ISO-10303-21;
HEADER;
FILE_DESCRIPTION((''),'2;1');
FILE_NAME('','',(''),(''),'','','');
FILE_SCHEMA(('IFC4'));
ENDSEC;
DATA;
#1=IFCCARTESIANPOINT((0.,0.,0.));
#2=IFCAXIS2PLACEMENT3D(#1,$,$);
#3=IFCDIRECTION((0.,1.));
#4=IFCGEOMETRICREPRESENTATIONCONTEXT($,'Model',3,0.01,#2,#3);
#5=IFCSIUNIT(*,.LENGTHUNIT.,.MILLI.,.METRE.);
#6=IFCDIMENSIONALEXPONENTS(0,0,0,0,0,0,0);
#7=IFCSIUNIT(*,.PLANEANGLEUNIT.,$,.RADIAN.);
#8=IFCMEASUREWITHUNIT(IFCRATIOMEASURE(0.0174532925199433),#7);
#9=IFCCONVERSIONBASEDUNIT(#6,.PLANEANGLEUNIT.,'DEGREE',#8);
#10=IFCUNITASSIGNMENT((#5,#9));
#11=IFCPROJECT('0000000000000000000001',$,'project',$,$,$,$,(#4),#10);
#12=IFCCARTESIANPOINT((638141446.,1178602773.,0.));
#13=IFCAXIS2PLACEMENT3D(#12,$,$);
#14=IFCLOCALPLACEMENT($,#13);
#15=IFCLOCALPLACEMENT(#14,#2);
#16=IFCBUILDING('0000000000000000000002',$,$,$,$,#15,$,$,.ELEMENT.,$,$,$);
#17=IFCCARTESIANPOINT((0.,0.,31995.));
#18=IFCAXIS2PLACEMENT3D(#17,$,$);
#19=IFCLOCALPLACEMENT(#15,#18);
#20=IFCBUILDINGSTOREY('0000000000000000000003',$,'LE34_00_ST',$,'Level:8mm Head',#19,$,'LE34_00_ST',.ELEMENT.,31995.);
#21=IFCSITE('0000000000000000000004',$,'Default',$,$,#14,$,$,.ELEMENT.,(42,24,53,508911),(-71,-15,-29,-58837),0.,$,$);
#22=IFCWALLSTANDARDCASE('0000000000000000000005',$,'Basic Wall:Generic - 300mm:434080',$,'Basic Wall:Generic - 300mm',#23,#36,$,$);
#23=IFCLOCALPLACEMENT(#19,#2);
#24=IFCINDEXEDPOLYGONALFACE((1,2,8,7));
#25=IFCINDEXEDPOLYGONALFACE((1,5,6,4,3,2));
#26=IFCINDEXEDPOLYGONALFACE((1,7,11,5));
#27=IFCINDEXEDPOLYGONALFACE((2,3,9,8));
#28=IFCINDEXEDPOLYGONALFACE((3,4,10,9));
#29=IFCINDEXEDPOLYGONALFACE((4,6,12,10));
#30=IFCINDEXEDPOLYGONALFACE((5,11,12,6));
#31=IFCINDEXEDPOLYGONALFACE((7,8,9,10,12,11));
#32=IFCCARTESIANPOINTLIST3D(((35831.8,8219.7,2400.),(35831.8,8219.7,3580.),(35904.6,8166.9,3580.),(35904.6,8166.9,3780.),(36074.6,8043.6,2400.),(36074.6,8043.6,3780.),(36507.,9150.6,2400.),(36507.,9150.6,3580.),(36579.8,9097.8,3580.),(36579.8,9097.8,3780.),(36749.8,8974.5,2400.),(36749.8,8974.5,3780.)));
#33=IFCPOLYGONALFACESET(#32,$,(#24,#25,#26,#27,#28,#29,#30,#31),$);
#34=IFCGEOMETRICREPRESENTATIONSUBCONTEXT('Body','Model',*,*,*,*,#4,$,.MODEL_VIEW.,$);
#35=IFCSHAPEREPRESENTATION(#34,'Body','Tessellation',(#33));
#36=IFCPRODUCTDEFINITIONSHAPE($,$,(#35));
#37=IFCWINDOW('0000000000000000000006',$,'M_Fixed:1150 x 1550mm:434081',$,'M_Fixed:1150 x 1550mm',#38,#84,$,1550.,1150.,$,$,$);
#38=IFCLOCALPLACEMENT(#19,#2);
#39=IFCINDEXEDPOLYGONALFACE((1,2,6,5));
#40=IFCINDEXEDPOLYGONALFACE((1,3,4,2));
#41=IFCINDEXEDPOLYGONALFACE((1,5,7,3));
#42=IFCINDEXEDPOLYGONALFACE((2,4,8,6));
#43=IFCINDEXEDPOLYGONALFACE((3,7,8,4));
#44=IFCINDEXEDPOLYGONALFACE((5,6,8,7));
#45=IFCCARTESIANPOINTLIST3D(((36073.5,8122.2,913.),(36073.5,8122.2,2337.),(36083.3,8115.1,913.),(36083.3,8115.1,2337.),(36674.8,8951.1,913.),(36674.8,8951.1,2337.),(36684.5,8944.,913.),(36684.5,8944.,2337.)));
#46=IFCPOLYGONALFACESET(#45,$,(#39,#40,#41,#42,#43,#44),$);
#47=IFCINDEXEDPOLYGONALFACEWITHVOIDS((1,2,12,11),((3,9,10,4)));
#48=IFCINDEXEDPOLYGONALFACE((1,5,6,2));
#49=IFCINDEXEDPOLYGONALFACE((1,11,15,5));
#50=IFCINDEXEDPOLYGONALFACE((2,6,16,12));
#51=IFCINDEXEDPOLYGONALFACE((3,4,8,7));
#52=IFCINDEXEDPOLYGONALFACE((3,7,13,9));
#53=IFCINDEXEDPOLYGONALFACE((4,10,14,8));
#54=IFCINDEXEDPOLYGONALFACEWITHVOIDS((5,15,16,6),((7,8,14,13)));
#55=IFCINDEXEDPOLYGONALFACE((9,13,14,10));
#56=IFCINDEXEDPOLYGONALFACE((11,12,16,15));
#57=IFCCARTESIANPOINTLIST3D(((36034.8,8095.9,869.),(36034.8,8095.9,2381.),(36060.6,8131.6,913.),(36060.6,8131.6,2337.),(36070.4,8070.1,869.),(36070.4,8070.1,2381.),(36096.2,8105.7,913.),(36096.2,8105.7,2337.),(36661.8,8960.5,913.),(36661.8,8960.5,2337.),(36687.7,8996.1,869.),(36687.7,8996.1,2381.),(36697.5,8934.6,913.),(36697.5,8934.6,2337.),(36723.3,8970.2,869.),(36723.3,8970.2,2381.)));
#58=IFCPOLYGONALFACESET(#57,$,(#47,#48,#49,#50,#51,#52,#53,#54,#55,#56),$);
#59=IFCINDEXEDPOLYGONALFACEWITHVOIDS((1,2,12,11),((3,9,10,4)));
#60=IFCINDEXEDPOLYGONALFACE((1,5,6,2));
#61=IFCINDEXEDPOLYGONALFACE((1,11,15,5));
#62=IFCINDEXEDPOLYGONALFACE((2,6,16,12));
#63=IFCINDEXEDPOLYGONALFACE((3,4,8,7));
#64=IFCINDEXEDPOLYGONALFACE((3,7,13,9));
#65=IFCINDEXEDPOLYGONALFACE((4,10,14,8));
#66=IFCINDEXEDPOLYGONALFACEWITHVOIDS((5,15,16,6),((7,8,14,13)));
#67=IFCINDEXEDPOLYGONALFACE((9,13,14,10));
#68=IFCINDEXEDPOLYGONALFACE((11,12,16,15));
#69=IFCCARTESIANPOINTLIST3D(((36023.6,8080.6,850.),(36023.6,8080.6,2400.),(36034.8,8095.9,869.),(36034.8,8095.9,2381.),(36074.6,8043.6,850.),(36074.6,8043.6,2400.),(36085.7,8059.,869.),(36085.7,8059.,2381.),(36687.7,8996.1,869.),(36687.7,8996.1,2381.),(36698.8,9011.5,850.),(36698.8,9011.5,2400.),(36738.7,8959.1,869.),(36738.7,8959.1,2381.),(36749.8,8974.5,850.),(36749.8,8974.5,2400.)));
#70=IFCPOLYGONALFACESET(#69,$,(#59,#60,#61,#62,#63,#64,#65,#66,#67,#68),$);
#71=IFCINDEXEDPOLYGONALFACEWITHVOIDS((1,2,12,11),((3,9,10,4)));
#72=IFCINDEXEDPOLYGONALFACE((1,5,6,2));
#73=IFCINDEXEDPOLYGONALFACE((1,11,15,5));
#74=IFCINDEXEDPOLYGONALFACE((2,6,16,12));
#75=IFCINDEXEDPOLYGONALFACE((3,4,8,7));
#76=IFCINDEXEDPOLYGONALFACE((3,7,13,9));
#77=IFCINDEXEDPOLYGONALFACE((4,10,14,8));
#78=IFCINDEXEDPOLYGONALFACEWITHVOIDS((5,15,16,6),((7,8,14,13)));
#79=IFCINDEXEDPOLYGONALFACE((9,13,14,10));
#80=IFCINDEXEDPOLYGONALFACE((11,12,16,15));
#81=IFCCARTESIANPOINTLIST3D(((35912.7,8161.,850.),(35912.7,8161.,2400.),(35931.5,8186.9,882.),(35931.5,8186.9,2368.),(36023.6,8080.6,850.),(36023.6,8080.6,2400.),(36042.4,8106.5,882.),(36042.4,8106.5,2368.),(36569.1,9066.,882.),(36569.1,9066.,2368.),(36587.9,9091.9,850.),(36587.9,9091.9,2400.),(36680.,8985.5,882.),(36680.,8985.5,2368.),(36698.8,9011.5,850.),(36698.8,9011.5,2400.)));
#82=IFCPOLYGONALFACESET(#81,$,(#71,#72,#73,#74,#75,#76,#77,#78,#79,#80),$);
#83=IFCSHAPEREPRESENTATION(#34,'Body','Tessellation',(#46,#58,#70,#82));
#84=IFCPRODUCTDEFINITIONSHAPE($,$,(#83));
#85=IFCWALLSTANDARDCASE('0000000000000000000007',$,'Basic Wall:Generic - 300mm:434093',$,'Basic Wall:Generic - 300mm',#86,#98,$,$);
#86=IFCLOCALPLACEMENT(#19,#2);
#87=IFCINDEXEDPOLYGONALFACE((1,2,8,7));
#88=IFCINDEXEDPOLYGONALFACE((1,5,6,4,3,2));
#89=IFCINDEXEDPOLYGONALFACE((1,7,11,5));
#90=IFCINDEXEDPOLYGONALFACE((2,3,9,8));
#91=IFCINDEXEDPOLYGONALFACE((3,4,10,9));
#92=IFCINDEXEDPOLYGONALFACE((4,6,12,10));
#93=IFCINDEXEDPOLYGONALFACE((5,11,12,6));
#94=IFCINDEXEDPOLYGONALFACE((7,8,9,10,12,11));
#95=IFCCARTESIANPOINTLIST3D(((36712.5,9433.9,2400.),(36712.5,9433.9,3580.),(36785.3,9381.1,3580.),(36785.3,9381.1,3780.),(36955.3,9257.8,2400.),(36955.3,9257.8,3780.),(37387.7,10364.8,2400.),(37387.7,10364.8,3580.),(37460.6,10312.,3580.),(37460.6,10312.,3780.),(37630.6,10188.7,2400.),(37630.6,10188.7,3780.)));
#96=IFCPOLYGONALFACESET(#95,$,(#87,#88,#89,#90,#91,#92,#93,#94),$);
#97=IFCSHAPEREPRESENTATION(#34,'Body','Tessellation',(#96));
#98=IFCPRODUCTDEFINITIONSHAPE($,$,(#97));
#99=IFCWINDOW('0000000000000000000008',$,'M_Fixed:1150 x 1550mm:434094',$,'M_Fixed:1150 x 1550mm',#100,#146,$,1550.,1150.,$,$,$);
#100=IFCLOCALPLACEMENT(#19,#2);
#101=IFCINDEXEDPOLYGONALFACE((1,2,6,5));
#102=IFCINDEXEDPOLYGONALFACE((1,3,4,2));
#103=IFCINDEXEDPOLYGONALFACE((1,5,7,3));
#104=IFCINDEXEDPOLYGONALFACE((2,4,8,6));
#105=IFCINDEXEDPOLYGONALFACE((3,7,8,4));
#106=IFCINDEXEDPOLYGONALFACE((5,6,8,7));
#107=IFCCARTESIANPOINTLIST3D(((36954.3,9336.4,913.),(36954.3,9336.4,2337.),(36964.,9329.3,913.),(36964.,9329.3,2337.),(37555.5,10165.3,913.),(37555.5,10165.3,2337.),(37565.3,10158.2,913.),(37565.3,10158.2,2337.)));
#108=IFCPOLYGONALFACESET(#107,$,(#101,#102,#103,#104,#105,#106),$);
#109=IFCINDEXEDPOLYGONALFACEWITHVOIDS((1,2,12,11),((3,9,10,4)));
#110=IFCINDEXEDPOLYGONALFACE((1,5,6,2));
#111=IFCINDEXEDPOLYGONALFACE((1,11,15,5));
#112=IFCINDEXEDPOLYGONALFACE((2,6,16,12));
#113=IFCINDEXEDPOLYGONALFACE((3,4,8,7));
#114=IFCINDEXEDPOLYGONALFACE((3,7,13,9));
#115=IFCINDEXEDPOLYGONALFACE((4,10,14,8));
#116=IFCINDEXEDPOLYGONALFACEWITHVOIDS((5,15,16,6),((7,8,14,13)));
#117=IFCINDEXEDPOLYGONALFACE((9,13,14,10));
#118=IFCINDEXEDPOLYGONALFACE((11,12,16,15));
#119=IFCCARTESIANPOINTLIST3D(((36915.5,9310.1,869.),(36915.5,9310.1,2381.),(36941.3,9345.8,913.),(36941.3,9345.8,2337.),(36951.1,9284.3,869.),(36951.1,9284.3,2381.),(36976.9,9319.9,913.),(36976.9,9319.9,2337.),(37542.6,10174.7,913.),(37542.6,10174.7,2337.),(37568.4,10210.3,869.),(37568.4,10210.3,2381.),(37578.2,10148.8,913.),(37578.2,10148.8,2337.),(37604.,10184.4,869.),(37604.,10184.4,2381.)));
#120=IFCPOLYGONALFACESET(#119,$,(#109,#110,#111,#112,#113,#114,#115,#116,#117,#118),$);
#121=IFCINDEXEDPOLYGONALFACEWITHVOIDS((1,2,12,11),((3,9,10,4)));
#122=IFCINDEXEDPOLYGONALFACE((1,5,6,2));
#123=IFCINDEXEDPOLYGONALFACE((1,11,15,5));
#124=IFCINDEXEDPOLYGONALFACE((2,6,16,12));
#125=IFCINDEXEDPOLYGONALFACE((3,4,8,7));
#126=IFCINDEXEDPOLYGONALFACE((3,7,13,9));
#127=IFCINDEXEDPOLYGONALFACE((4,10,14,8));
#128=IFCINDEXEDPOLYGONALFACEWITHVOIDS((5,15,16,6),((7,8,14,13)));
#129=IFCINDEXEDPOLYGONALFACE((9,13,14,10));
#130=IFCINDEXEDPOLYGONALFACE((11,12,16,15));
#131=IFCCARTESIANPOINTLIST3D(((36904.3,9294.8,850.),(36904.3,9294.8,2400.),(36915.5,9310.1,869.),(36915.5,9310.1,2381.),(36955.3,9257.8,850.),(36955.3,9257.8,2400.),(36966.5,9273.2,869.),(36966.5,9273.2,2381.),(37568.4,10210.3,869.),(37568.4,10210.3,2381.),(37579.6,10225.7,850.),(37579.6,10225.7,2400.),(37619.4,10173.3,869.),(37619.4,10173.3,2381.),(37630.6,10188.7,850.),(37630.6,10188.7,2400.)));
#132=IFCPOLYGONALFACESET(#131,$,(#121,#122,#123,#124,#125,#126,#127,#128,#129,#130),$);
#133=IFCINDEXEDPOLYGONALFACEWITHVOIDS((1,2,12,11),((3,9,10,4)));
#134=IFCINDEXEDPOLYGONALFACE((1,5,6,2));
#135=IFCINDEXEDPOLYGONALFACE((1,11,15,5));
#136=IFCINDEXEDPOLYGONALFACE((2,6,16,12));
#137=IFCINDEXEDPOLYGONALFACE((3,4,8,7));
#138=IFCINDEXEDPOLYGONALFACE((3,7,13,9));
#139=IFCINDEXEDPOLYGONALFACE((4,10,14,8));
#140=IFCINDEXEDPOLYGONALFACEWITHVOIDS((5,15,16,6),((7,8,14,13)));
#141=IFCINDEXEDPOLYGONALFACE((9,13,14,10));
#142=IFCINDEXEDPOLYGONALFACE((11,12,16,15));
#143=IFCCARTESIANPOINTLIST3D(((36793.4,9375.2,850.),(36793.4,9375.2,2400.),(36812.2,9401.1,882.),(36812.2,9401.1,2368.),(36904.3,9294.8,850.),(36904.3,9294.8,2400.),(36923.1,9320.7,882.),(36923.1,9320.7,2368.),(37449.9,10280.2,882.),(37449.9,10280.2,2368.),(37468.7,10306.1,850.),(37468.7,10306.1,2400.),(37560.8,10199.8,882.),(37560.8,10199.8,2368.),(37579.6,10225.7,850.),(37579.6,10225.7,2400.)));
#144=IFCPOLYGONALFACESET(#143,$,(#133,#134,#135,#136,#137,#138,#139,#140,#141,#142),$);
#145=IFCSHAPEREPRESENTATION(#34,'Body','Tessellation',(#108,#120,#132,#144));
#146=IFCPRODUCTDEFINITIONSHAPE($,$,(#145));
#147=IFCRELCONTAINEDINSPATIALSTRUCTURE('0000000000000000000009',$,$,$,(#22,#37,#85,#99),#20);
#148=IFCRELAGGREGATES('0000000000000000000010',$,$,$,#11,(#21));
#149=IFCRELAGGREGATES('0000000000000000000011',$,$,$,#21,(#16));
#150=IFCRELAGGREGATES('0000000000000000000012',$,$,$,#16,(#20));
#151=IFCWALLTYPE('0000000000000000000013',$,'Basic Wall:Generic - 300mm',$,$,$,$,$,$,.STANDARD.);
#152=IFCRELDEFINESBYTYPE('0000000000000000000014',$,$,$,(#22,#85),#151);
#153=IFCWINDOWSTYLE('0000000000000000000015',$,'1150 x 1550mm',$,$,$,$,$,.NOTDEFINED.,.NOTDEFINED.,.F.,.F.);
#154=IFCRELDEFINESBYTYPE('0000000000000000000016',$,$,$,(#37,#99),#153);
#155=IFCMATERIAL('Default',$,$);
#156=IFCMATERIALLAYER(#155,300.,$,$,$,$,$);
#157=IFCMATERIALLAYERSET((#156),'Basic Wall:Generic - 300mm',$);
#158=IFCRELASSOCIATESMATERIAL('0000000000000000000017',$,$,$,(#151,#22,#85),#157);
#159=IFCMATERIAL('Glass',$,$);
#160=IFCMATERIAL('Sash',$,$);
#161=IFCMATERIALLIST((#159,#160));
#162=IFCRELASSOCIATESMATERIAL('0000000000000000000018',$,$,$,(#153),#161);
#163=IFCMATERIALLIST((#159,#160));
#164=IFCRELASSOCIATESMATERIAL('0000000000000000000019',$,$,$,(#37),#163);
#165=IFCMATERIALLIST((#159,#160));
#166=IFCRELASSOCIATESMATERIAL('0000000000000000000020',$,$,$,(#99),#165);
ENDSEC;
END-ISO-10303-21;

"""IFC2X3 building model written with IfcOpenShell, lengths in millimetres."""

from ifc_helpers import new_model, entity, si_unit, converted_unit, direction, frame, frame_2d, origin, place, context, subcontext, project, spatial, polyline, rectangle, outline, extrude, clip, bounded_halfspace, source, transform, mapped, material, material_list, layer, layer_set, layer_usage, type_object, type_shapes, element, fill, save


model = new_model("IFC2X3")

# Units and contexts
model_context = context("Model", 3, precision=0.01, world=origin(), true_north=direction((0.0, 1.0)))
body_context = subcontext(model_context, "Body", "Model", "MODEL_VIEW")
ifc_project = project(units=[si_unit("LENGTHUNIT", "METRE", prefix="MILLI"), converted_unit("PLANEANGLEUNIT", "DEGREE", entity("IfcRatioMeasure", 0.0174532925199433), si_unit("PLANEANGLEUNIT", "RADIAN"), dimensions=[0, 0, 0, 0, 0, 0, 0])], contexts=[model_context])

# Site, building, storey
site_placement = place(None, frame((638141446.0, 1178602773.0, 0.0)))
site = spatial("IfcSite", under=ifc_project, at=site_placement, Name="Default", CompositionType="ELEMENT", RefLatitude=(42, 24, 53, 508911), RefLongitude=(-71, -15, -29, -58837), RefElevation=0.0)
building_placement = place(site_placement, origin())
building = spatial("IfcBuilding", under=site, at=building_placement, CompositionType="ELEMENT")
storey_placement = place(building_placement, frame((0.0, 0.0, 31995.0)))
storey = spatial("IfcBuildingStorey", under=building, at=storey_placement, Name="LE34_00_ST", ObjectType="Level:8mm Head", LongName="LE34_00_ST", CompositionType="ELEMENT", Elevation=31995.0)

# Walls, openings, windows
ifc_material_1 = material(Name="Default")
ifc_layer_1 = layer(ifc_material_1, 300.0)
ifc_layer_set_1 = layer_set([ifc_layer_1], Name="Basic Wall:Generic - 300mm")
wall_type_1 = type_object("IfcWallType", Name="Basic Wall:Generic - 300mm", PredefinedType="STANDARD", material=ifc_layer_set_1)
ifc_material_2 = material(Name="Glass")
ifc_material_3 = material(Name="Sash")
ifc_material_list_1 = material_list([ifc_material_2, ifc_material_3])
window_style_1 = type_object("IfcWindowStyle", Name="1150 x 1550mm", ConstructionType="NOTDEFINED", OperationType="NOTDEFINED", ParameterTakesPrecedence=False, Sizeable=False, material=ifc_material_list_1)
shared_shape_1 = source(origin(), body_context, "Body", "SweptSolid", [
    extrude(rectangle(XDim=1024.0, YDim=12.0, at=frame_2d((0.0, 0.0), x_axis=(1.0, 0.0))), frame((575.0, 285.0, 63.0), z_axis=(0.0, 0.0, 1.0), x_axis=(-1.0, 0.0, 0.0)), (0.0, 0.0, 1.0), 1424.0),
    extrude(outline(polyline([(-556.0, -756.0), (556.0, -756.0), (556.0, 756.0), (-556.0, 756.0), (-556.0, -756.0)]), holes=[polyline([(-512.0, -712.0), (-512.0, 712.0), (512.0, 712.0), (512.0, -712.0), (-512.0, -712.0)])]), frame((575.0, 307.0, 775.0), z_axis=(0.0, -1.0, 0.0), x_axis=(-1.0, 0.0, 0.0)), (0.0, 0.0, 1.0), 44.0),
    extrude(outline(polyline([(-575.0, -775.0), (575.0, -775.0), (575.0, 775.0), (-575.0, 775.0), (-575.0, -775.0)]), holes=[polyline([(-556.0, -756.0), (-556.0, 756.0), (556.0, 756.0), (556.0, -756.0), (-556.0, -756.0)])]), frame((575.0, 326.0, 775.0), z_axis=(0.0, -1.0, 0.0), x_axis=(-1.0, 0.0, 0.0)), (0.0, 0.0, 1.0), 63.0),
    extrude(outline(polyline([(-575.0, -775.0), (575.0, -775.0), (575.0, 775.0), (-575.0, 775.0), (-575.0, -775.0)]), holes=[polyline([(-543.0, -743.0), (-543.0, 743.0), (543.0, 743.0), (543.0, -743.0), (-543.0, -743.0)])]), frame((575.0, 263.0, 775.0), z_axis=(0.0, -1.0, 0.0), x_axis=(-1.0, 0.0, 0.0)), (0.0, 0.0, 1.0), 137.0),
])
type_shapes(window_style_1, [shared_shape_1])
ifc_layer_usage_1 = layer_usage(ifc_layer_set_1, "AXIS2", "POSITIVE", -150.0)
wall_1_placement = place(storey_placement, frame((35953.2, 8131.6, 2400.0), z_axis=(0.0, 0.0, 1.0), x_axis=(0.587164, 0.809468, 0.0)))
wall_1 = element("IfcWallStandardCase", 1, at=wall_1_placement, inside=storey, type_object=wall_type_1, material=ifc_layer_usage_1, Name="Basic Wall:Generic - 300mm:434080", ObjectType="Basic Wall:Generic - 300mm", context=body_context, shape_type="Clipping", body=[
    clip(clip(extrude(rectangle(XDim=1150.0, YDim=300.0, at=frame_2d((575.0, 0.0), x_axis=(-1.0, 0.0))), origin(), (0.0, 0.0, 1.0), 1380.0), bounded_halfspace(frame((0.0, 60.0, 1180.0), z_axis=(0.0, 0.0, -1.0), x_axis=(0.0, 1.0, 0.0)), True, frame((0.0, 60.0, 1180.0), z_axis=(0.0, 0.0, -1.0), x_axis=(0.0, 1.0, 0.0)), polyline([(0.0, 0.0), (90.0, 0.0), (90.0, 1150.0), (0.0, 1150.0), (0.0, 0.0)]))), bounded_halfspace(frame((1150.0, 60.0, 1180.0), z_axis=(0.0, -1.0, 0.0), x_axis=(0.0, 0.0, 1.0)), True, frame((1150.0, 60.0, 1180.0), z_axis=(0.0, -1.0, 0.0), x_axis=(0.0, 0.0, 1.0)), polyline([(0.0, 0.0), (200.0, 0.0), (200.0, 1150.0), (0.0, 1150.0), (0.0, 0.0)]))),
])
opening_1_placement = place(wall_1_placement, frame((1150.0, 150.0, -1550.0)))
opening_1 = element("IfcOpeningElement", 2, at=opening_1_placement, cuts=wall_1, ObjectType="Opening", context=body_context, shape_type="SweptSolid", body=[
    extrude(rectangle(XDim=1550.0, YDim=1150.0, at=frame_2d((775.0, 575.0), x_axis=(1.0, 0.0))), frame((0.0, 0.0, 0.0), z_axis=(0.0, -1.0, 0.0), x_axis=(0.0, 0.0, 1.0)), (0.0, 0.0, 1.0), 300.0),
])
ifc_material_list_2 = material_list([ifc_material_2, ifc_material_3])
window_1_placement = place(opening_1_placement, frame((0.0, 26.0, 0.0), z_axis=(0.0, 0.0, 1.0), x_axis=(-1.0, 0.0, 0.0)))
window_1 = element("IfcWindow", 3, at=window_1_placement, inside=storey, type_object=window_style_1, material=ifc_material_list_2, Name="M_Fixed:1150 x 1550mm:434081", ObjectType="M_Fixed:1150 x 1550mm", OverallHeight=1550.0, OverallWidth=1150.0, context=body_context, shape_type="MappedRepresentation", body=[
    mapped(shared_shape_1, transform((0.0, 0.0, 0.0), scale=1.0)),
])
fill(opening_1, window_1)
ifc_layer_usage_2 = layer_usage(ifc_layer_set_1, "AXIS2", "POSITIVE", -150.0)
wall_2_placement = place(storey_placement, frame((36833.9, 9345.8, 2400.0), z_axis=(0.0, 0.0, 1.0), x_axis=(0.587164, 0.809468, 0.0)))
wall_2 = element("IfcWallStandardCase", 4, at=wall_2_placement, inside=storey, type_object=wall_type_1, material=ifc_layer_usage_2, Name="Basic Wall:Generic - 300mm:434093", ObjectType="Basic Wall:Generic - 300mm", context=body_context, shape_type="Clipping", body=[
    clip(clip(extrude(rectangle(XDim=1150.0, YDim=300.0, at=frame_2d((575.0, 0.0), x_axis=(-1.0, 0.0))), origin(), (0.0, 0.0, 1.0), 1380.0), bounded_halfspace(frame((0.0, 60.0, 1180.0), z_axis=(0.0, 0.0, -1.0), x_axis=(0.0, 1.0, 0.0)), True, frame((0.0, 60.0, 1180.0), z_axis=(0.0, 0.0, -1.0), x_axis=(0.0, 1.0, 0.0)), polyline([(0.0, 0.0), (90.0, 0.0), (90.0, 1150.0), (0.0, 1150.0), (0.0, 0.0)]))), bounded_halfspace(frame((1150.0, 60.0, 1180.0), z_axis=(0.0, -1.0, 0.0), x_axis=(0.0, 0.0, 1.0)), True, frame((1150.0, 60.0, 1180.0), z_axis=(0.0, -1.0, 0.0), x_axis=(0.0, 0.0, 1.0)), polyline([(0.0, 0.0), (200.0, 0.0), (200.0, 1150.0), (0.0, 1150.0), (0.0, 0.0)]))),
])
opening_2_placement = place(wall_2_placement, frame((1150.0, 150.0, -1550.0)))
opening_2 = element("IfcOpeningElement", 5, at=opening_2_placement, cuts=wall_2, ObjectType="Opening", context=body_context, shape_type="SweptSolid", body=[
    extrude(rectangle(XDim=1550.0, YDim=1150.0, at=frame_2d((775.0, 575.0), x_axis=(1.0, 0.0))), frame((0.0, 0.0, 0.0), z_axis=(0.0, -1.0, 0.0), x_axis=(0.0, 0.0, 1.0)), (0.0, 0.0, 1.0), 300.0),
])
ifc_material_list_3 = material_list([ifc_material_2, ifc_material_3])
window_2_placement = place(opening_2_placement, frame((0.0, 26.0, 0.0), z_axis=(0.0, 0.0, 1.0), x_axis=(-1.0, 0.0, 0.0)))
window_2 = element("IfcWindow", 6, at=window_2_placement, inside=storey, type_object=window_style_1, material=ifc_material_list_3, Name="M_Fixed:1150 x 1550mm:434094", ObjectType="M_Fixed:1150 x 1550mm", OverallHeight=1550.0, OverallWidth=1150.0, context=body_context, shape_type="MappedRepresentation", body=[
    mapped(shared_shape_1, transform((0.0, 0.0, 0.0), scale=1.0)),
])
fill(opening_2, window_2)

save(model, "model.ifc")
